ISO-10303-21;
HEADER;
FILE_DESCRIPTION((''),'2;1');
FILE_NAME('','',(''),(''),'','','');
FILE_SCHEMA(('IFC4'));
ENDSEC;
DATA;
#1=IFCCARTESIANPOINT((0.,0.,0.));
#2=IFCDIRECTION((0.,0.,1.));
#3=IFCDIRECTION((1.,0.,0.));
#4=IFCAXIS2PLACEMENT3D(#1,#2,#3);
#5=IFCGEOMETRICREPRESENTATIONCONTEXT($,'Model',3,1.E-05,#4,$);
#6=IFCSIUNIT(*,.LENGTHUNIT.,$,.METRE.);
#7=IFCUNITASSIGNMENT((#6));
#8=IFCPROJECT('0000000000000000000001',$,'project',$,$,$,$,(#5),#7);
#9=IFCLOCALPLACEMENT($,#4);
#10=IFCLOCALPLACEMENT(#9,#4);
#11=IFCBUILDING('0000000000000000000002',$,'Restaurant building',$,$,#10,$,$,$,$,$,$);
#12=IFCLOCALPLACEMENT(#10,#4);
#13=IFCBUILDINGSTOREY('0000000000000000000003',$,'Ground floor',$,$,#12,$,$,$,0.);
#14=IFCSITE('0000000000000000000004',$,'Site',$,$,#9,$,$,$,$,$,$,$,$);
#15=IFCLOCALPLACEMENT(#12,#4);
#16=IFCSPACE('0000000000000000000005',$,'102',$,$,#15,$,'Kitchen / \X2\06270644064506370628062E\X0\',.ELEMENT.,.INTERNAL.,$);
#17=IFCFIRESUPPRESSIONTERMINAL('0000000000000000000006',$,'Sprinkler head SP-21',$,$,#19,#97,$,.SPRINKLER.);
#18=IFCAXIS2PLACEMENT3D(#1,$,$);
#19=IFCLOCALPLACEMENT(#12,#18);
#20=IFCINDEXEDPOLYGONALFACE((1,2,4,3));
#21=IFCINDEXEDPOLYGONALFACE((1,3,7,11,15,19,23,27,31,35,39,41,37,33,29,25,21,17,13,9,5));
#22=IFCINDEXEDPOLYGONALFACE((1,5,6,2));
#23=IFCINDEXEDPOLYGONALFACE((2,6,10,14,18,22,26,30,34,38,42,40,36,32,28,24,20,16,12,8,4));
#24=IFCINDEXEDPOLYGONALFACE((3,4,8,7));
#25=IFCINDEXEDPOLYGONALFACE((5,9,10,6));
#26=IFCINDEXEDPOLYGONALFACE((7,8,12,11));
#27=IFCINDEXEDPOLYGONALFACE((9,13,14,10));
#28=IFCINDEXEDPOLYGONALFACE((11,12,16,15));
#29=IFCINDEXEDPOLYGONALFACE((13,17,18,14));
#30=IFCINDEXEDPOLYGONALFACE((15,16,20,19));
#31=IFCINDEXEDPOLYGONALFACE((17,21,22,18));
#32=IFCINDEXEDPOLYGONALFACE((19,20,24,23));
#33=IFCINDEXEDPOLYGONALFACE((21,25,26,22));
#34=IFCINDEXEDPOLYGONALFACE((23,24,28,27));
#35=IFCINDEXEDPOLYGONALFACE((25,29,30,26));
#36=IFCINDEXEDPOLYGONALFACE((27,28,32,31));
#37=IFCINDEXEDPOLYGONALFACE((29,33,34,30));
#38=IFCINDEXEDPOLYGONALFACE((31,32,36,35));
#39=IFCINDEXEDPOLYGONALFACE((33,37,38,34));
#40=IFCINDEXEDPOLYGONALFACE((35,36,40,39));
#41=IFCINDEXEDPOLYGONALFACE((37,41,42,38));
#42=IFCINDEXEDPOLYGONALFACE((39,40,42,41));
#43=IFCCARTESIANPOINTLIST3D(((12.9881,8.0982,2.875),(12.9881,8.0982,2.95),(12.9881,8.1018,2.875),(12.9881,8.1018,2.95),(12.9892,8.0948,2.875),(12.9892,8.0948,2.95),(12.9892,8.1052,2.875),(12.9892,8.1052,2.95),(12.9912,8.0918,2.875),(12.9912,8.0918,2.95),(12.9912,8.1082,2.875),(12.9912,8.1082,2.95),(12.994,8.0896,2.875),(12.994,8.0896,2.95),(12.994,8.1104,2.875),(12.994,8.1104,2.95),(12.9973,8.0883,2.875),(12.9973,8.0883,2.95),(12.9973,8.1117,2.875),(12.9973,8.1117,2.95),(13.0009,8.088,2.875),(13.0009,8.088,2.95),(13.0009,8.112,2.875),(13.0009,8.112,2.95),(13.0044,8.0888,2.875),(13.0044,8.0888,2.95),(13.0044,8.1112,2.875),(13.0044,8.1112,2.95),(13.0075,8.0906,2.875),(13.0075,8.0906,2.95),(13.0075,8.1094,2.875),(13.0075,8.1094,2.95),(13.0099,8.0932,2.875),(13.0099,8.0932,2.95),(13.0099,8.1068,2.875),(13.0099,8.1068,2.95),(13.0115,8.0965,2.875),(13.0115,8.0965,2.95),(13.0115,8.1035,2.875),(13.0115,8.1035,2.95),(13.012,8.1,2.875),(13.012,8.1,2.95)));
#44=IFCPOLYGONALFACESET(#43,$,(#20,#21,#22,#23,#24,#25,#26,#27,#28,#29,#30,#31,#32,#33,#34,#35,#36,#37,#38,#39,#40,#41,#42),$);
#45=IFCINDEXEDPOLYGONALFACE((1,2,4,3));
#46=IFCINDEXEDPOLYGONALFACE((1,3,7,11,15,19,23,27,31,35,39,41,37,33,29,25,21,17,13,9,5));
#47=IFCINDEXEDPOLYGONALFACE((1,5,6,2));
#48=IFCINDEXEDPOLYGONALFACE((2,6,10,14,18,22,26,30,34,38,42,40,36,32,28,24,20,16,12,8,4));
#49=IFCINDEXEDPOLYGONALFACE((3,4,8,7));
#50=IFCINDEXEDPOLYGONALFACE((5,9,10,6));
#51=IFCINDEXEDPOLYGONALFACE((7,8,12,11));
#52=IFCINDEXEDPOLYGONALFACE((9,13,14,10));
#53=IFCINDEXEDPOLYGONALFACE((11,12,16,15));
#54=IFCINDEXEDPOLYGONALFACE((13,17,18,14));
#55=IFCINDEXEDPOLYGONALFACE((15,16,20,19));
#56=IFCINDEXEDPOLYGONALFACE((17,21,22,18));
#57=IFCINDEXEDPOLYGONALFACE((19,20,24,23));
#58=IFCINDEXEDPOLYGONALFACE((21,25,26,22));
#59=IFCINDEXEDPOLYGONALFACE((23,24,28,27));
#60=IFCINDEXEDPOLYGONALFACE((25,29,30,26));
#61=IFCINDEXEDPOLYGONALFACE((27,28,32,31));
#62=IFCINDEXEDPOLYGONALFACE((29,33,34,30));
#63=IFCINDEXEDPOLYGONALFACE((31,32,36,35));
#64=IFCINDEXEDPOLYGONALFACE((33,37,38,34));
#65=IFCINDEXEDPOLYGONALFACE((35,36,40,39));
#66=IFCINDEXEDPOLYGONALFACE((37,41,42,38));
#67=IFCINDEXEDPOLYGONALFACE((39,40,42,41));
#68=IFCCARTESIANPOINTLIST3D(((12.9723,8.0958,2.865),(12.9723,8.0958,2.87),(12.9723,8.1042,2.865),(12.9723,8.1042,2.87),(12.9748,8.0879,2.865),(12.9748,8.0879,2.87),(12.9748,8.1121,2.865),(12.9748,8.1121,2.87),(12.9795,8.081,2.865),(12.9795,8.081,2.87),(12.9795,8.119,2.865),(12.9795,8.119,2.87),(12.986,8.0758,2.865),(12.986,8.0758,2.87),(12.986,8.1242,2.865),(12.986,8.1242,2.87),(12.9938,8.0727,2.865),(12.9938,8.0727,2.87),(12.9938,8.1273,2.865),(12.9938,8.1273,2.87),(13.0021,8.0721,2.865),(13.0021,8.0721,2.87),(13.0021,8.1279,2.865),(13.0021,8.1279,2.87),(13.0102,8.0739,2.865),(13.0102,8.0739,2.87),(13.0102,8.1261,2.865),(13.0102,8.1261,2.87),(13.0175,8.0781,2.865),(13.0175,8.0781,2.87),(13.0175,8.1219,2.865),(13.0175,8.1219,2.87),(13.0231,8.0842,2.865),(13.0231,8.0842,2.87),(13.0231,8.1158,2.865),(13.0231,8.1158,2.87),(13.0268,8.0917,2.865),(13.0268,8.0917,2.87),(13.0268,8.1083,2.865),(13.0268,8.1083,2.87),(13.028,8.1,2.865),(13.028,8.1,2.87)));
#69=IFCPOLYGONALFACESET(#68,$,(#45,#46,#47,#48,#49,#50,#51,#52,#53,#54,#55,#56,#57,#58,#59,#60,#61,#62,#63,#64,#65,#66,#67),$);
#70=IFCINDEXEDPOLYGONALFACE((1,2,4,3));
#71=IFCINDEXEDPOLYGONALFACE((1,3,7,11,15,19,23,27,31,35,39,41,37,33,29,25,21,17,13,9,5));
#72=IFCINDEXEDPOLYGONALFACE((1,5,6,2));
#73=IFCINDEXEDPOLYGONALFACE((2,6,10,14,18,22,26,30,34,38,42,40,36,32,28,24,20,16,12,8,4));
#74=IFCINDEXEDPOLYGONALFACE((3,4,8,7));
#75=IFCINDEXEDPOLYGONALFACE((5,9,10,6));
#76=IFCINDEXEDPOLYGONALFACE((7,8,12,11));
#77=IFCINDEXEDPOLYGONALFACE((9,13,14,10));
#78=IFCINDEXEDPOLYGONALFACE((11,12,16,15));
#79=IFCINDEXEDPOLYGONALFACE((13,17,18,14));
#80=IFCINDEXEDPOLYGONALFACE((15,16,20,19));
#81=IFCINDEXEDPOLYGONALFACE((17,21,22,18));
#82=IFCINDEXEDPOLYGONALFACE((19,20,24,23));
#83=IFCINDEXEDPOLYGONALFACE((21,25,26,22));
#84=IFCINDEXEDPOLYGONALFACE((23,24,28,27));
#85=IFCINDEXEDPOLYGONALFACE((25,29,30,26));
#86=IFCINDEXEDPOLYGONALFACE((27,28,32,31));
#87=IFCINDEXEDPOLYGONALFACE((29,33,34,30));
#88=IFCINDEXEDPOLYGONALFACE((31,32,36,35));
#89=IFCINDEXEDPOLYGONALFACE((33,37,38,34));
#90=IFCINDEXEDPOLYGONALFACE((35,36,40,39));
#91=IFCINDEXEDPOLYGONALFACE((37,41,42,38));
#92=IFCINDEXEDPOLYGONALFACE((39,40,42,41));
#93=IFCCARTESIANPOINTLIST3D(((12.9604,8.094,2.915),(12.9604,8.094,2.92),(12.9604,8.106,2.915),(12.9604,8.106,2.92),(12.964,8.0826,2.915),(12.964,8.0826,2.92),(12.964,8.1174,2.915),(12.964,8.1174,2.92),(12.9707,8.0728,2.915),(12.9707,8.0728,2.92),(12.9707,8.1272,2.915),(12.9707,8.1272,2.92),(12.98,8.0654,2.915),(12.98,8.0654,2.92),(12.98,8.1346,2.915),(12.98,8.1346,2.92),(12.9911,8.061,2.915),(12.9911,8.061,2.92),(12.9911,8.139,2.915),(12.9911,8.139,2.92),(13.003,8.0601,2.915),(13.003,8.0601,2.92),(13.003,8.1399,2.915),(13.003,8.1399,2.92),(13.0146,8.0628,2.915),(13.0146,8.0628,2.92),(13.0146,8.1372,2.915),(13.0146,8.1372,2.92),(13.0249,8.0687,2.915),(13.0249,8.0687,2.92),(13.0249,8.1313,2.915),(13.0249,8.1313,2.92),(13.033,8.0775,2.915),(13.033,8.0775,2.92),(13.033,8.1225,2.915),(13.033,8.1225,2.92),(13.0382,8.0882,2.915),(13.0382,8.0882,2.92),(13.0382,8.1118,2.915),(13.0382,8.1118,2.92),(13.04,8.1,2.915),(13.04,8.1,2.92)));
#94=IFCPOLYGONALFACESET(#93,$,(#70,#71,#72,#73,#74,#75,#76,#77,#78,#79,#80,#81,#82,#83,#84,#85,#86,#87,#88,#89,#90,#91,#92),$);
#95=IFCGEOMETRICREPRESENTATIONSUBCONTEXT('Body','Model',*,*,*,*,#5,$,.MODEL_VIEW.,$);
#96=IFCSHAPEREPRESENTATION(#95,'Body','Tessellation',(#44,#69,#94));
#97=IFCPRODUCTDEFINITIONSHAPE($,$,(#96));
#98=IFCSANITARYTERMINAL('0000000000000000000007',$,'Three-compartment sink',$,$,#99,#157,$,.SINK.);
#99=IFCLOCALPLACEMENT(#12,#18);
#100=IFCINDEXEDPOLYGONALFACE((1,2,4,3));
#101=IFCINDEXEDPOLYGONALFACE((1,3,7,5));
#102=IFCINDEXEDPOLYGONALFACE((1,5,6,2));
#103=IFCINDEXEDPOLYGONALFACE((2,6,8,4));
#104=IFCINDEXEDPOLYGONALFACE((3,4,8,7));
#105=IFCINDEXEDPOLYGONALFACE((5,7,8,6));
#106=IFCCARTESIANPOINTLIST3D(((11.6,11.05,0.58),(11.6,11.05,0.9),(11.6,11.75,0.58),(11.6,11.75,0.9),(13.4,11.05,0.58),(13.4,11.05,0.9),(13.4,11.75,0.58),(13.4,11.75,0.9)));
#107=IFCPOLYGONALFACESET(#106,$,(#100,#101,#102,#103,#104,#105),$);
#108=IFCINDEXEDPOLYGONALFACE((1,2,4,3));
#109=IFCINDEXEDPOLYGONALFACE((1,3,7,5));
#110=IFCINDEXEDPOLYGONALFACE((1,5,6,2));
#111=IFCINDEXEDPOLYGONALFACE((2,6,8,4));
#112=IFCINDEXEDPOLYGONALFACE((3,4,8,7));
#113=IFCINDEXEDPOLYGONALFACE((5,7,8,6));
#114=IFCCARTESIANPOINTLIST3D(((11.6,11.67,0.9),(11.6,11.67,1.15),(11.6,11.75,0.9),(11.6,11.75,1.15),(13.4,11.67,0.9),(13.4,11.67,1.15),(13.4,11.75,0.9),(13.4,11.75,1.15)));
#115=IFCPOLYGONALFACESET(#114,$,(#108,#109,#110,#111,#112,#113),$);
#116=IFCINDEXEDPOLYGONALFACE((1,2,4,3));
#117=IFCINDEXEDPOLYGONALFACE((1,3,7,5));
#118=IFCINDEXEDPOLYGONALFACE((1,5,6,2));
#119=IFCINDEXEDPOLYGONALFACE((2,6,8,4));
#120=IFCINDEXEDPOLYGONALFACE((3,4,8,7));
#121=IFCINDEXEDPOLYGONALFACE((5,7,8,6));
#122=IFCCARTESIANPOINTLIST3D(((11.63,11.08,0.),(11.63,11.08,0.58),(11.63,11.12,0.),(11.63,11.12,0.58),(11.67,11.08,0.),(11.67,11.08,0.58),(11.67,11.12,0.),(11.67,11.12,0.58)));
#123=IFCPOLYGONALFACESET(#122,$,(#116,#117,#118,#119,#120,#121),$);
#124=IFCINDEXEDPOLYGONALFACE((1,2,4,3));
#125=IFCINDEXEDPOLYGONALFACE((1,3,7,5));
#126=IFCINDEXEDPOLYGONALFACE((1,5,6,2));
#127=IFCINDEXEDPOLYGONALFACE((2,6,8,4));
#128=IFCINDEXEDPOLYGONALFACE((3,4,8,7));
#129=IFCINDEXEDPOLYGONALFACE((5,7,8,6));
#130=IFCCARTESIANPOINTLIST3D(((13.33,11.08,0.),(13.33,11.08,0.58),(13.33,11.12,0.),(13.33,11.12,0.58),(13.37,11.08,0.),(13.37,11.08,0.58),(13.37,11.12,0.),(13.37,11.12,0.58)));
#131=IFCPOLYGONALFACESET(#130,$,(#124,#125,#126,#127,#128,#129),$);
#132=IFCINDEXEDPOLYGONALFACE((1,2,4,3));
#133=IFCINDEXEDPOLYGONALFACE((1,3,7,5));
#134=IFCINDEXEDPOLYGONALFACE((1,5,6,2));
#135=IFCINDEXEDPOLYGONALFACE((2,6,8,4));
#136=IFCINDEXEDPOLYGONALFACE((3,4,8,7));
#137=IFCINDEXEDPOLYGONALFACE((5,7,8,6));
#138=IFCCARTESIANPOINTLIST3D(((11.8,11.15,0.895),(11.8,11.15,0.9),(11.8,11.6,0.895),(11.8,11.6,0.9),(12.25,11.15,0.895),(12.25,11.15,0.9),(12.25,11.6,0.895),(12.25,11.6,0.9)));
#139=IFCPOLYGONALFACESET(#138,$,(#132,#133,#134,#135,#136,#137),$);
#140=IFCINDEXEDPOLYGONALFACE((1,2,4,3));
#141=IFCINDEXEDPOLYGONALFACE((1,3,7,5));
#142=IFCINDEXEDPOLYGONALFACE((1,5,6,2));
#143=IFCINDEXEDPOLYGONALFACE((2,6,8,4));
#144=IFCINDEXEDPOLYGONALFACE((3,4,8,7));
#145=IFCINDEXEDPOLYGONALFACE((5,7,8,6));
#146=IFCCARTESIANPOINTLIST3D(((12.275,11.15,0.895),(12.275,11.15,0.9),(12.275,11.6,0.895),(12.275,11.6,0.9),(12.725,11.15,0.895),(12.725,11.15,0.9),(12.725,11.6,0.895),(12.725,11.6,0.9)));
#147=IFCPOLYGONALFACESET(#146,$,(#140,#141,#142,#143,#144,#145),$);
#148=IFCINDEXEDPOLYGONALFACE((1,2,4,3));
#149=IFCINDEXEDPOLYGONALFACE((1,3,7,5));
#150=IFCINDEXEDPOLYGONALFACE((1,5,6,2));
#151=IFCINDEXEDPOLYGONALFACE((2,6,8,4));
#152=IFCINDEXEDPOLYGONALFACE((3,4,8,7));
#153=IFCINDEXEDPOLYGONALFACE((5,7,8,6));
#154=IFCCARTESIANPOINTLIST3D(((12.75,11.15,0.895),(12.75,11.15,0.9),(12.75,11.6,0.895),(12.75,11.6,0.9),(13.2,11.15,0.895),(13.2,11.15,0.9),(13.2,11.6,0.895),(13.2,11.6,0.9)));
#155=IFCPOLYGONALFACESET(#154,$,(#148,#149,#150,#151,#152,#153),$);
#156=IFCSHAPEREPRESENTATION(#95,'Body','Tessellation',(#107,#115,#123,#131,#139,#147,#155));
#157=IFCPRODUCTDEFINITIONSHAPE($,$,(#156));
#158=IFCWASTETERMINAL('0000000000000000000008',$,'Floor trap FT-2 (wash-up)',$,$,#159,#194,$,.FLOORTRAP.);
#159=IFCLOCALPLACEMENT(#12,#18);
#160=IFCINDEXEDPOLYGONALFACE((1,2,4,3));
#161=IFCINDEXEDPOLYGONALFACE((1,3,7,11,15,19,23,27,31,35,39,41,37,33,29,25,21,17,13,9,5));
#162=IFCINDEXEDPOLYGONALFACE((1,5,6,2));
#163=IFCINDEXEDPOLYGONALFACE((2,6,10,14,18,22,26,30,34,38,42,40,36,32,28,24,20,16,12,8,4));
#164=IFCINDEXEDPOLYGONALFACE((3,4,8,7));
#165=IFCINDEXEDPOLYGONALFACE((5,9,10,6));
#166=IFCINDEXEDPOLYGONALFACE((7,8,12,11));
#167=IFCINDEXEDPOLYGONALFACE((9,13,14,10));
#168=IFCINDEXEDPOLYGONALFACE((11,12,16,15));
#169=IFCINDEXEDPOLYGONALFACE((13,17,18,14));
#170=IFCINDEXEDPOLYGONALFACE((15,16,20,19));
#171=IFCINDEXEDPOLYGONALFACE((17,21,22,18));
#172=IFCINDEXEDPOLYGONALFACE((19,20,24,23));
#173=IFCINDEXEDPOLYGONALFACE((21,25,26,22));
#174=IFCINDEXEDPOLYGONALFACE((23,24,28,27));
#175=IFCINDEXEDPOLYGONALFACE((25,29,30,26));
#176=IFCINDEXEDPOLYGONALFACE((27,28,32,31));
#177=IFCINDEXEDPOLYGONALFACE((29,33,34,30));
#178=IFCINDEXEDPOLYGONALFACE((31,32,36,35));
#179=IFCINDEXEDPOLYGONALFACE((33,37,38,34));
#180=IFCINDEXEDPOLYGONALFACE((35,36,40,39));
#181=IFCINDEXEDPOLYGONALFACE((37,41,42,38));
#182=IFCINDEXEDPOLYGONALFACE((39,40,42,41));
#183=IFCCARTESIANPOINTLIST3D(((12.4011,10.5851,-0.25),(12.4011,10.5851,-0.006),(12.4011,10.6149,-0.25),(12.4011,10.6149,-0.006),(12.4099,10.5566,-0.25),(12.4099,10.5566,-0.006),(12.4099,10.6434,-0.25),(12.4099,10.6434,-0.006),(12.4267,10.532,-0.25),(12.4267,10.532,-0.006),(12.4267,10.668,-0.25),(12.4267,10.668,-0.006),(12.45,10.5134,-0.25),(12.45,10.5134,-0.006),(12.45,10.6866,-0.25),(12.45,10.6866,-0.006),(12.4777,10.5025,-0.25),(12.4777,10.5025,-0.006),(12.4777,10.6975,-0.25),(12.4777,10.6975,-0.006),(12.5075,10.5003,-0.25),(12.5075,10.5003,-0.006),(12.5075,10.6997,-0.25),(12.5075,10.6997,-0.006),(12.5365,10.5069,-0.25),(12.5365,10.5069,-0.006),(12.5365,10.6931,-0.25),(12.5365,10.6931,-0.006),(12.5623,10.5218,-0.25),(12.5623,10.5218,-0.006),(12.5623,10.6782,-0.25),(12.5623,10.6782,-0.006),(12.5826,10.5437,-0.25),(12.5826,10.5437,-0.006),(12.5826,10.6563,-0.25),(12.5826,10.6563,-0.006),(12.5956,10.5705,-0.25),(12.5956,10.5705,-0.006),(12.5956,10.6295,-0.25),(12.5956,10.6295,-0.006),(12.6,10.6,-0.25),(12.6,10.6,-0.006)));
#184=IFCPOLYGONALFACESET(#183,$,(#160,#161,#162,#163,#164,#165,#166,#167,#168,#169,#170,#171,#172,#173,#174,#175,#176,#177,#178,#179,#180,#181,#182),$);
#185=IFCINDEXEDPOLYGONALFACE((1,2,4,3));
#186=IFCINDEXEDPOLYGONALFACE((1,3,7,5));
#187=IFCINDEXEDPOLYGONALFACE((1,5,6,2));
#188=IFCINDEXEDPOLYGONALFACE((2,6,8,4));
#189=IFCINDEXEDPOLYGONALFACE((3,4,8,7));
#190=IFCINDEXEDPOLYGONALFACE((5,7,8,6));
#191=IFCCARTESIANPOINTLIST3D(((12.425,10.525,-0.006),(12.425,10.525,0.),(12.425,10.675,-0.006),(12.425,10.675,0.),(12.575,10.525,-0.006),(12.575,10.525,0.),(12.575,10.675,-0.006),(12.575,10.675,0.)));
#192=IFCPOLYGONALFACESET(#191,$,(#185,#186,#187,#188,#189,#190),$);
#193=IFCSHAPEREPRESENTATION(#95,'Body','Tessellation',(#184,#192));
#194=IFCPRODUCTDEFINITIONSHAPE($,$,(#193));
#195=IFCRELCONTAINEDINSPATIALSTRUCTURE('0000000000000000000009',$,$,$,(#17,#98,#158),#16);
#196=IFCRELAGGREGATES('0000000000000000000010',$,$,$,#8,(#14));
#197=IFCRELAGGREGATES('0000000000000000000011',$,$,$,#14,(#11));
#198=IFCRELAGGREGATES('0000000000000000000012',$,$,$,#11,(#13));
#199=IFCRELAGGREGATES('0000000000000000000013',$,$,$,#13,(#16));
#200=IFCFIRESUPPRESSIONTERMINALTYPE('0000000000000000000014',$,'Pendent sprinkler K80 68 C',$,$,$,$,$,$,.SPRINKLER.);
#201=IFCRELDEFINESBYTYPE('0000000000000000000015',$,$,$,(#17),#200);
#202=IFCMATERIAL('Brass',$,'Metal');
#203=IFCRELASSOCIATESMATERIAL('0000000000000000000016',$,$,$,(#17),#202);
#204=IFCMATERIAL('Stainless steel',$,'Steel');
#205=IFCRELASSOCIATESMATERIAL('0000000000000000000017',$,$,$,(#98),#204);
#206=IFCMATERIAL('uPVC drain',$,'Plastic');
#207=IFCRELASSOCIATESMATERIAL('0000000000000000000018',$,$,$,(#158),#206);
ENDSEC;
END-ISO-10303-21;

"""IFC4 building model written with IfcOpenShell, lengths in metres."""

from ifc_helpers import new_model, si_unit, frame, origin, origin_with_axes, origin_2d, place, context, subcontext, project, spatial, rectangle, circle, extrude, source, transform, mapped, material, type_object, type_shapes, element, save


model = new_model("IFC4")

# Units and contexts
model_context = context("Model", 3, precision=1e-05, world=origin_with_axes())
body_context = subcontext(model_context, "Body", "Model", "MODEL_VIEW")
ifc_project = project(units=[si_unit("LENGTHUNIT", "METRE")], contexts=[model_context])

# Site, building, storey
site_placement = place(None, origin_with_axes())
site = spatial("IfcSite", under=ifc_project, at=site_placement, Name="Site")
building_placement = place(site_placement, origin_with_axes())
building = spatial("IfcBuilding", under=site, at=building_placement, Name="Restaurant building")
storey_placement = place(building_placement, origin_with_axes())
storey = spatial("IfcBuildingStorey", under=building, at=storey_placement, Name="Ground floor", Elevation=0.0)

# Shared definitions
space_placement = place(storey_placement, origin_with_axes())
space = spatial("IfcSpace", under=storey, at=space_placement, Name="102", LongName="Kitchen / المطبخ", CompositionType="ELEMENT", PredefinedType="INTERNAL")

# Fire suppression terminal
ifc_material_1 = material(Name="Brass", Category="Metal")
fire_suppression_terminal_type = type_object("IfcFireSuppressionTerminalType", Name="Pendent sprinkler K80 68 C", PredefinedType="SPRINKLER")
shared_shape_1 = source(origin(), body_context, "Body", "SweptSolid", [
    extrude(circle(Radius=0.012, at=origin_2d()), frame((0.0, 0.0, -0.075)), (0.0, 0.0, 1.0), 0.075),
    extrude(circle(Radius=0.028, at=origin_2d()), frame((0.0, 0.0, -0.085)), (0.0, 0.0, 1.0), 0.005),
    extrude(circle(Radius=0.04, at=origin_2d()), frame((0.0, 0.0, -0.035)), (0.0, 0.0, 1.0), 0.005),
])
type_shapes(fire_suppression_terminal_type, [shared_shape_1])
for number, where, name in (
    (1, (13.0, 8.1, 2.95), "Sprinkler head SP-21"),
):
    element("IfcFireSuppressionTerminal", number, at=place(storey_placement, frame(where)), inside=space, type_object=fire_suppression_terminal_type, material=ifc_material_1, Name=name, PredefinedType="SPRINKLER", context=body_context, shape_type="MappedRepresentation", body=[
        mapped(shared_shape_1, transform((0.0, 0.0, 0.0))),
    ])

# Sanitary terminal
ifc_material_2 = material(Name="Stainless steel", Category="Steel")
sanitary_terminal_placement = place(storey_placement, frame((11.6, 11.05, 0.0)))
element("IfcSanitaryTerminal", 2, at=sanitary_terminal_placement, inside=space, material=ifc_material_2, Name="Three-compartment sink", PredefinedType="SINK", context=body_context, shape_type="SweptSolid", body=[
    extrude(rectangle(XDim=1.8, YDim=0.7, at=origin_2d()), frame((0.9, 0.35, 0.58)), (0.0, 0.0, 1.0), 0.32),
    extrude(rectangle(XDim=1.8, YDim=0.08, at=origin_2d()), frame((0.9, 0.66, 0.9)), (0.0, 0.0, 1.0), 0.25),
    extrude(rectangle(XDim=0.04, YDim=0.04, at=origin_2d()), frame((0.05, 0.05, 0.0)), (0.0, 0.0, 1.0), 0.58),
    extrude(rectangle(XDim=0.04, YDim=0.04, at=origin_2d()), frame((1.75, 0.05, 0.0)), (0.0, 0.0, 1.0), 0.58),
    extrude(rectangle(XDim=0.45, YDim=0.45, at=origin_2d()), frame((0.425, 0.325, 0.895)), (0.0, 0.0, 1.0), 0.005),
    extrude(rectangle(XDim=0.45, YDim=0.45, at=origin_2d()), frame((0.9, 0.325, 0.895)), (0.0, 0.0, 1.0), 0.005),
    extrude(rectangle(XDim=0.45, YDim=0.45, at=origin_2d()), frame((1.375, 0.325, 0.895)), (0.0, 0.0, 1.0), 0.005),
])

# Waste terminal
ifc_material_3 = material(Name="uPVC drain", Category="Plastic")
waste_terminal_placement = place(storey_placement, frame((12.5, 10.6, 0.0)))
element("IfcWasteTerminal", 3, at=waste_terminal_placement, inside=space, material=ifc_material_3, Name="Floor trap FT-2 (wash-up)", PredefinedType="FLOORTRAP", context=body_context, shape_type="SweptSolid", body=[
    extrude(circle(Radius=0.1, at=origin_2d()), frame((0.0, 0.0, -0.25)), (0.0, 0.0, 1.0), 0.244),
    extrude(rectangle(XDim=0.15, YDim=0.15, at=origin_2d()), frame((0.0, 0.0, -0.006)), (0.0, 0.0, 1.0), 0.006),
])

save(model, "model.ifc")
